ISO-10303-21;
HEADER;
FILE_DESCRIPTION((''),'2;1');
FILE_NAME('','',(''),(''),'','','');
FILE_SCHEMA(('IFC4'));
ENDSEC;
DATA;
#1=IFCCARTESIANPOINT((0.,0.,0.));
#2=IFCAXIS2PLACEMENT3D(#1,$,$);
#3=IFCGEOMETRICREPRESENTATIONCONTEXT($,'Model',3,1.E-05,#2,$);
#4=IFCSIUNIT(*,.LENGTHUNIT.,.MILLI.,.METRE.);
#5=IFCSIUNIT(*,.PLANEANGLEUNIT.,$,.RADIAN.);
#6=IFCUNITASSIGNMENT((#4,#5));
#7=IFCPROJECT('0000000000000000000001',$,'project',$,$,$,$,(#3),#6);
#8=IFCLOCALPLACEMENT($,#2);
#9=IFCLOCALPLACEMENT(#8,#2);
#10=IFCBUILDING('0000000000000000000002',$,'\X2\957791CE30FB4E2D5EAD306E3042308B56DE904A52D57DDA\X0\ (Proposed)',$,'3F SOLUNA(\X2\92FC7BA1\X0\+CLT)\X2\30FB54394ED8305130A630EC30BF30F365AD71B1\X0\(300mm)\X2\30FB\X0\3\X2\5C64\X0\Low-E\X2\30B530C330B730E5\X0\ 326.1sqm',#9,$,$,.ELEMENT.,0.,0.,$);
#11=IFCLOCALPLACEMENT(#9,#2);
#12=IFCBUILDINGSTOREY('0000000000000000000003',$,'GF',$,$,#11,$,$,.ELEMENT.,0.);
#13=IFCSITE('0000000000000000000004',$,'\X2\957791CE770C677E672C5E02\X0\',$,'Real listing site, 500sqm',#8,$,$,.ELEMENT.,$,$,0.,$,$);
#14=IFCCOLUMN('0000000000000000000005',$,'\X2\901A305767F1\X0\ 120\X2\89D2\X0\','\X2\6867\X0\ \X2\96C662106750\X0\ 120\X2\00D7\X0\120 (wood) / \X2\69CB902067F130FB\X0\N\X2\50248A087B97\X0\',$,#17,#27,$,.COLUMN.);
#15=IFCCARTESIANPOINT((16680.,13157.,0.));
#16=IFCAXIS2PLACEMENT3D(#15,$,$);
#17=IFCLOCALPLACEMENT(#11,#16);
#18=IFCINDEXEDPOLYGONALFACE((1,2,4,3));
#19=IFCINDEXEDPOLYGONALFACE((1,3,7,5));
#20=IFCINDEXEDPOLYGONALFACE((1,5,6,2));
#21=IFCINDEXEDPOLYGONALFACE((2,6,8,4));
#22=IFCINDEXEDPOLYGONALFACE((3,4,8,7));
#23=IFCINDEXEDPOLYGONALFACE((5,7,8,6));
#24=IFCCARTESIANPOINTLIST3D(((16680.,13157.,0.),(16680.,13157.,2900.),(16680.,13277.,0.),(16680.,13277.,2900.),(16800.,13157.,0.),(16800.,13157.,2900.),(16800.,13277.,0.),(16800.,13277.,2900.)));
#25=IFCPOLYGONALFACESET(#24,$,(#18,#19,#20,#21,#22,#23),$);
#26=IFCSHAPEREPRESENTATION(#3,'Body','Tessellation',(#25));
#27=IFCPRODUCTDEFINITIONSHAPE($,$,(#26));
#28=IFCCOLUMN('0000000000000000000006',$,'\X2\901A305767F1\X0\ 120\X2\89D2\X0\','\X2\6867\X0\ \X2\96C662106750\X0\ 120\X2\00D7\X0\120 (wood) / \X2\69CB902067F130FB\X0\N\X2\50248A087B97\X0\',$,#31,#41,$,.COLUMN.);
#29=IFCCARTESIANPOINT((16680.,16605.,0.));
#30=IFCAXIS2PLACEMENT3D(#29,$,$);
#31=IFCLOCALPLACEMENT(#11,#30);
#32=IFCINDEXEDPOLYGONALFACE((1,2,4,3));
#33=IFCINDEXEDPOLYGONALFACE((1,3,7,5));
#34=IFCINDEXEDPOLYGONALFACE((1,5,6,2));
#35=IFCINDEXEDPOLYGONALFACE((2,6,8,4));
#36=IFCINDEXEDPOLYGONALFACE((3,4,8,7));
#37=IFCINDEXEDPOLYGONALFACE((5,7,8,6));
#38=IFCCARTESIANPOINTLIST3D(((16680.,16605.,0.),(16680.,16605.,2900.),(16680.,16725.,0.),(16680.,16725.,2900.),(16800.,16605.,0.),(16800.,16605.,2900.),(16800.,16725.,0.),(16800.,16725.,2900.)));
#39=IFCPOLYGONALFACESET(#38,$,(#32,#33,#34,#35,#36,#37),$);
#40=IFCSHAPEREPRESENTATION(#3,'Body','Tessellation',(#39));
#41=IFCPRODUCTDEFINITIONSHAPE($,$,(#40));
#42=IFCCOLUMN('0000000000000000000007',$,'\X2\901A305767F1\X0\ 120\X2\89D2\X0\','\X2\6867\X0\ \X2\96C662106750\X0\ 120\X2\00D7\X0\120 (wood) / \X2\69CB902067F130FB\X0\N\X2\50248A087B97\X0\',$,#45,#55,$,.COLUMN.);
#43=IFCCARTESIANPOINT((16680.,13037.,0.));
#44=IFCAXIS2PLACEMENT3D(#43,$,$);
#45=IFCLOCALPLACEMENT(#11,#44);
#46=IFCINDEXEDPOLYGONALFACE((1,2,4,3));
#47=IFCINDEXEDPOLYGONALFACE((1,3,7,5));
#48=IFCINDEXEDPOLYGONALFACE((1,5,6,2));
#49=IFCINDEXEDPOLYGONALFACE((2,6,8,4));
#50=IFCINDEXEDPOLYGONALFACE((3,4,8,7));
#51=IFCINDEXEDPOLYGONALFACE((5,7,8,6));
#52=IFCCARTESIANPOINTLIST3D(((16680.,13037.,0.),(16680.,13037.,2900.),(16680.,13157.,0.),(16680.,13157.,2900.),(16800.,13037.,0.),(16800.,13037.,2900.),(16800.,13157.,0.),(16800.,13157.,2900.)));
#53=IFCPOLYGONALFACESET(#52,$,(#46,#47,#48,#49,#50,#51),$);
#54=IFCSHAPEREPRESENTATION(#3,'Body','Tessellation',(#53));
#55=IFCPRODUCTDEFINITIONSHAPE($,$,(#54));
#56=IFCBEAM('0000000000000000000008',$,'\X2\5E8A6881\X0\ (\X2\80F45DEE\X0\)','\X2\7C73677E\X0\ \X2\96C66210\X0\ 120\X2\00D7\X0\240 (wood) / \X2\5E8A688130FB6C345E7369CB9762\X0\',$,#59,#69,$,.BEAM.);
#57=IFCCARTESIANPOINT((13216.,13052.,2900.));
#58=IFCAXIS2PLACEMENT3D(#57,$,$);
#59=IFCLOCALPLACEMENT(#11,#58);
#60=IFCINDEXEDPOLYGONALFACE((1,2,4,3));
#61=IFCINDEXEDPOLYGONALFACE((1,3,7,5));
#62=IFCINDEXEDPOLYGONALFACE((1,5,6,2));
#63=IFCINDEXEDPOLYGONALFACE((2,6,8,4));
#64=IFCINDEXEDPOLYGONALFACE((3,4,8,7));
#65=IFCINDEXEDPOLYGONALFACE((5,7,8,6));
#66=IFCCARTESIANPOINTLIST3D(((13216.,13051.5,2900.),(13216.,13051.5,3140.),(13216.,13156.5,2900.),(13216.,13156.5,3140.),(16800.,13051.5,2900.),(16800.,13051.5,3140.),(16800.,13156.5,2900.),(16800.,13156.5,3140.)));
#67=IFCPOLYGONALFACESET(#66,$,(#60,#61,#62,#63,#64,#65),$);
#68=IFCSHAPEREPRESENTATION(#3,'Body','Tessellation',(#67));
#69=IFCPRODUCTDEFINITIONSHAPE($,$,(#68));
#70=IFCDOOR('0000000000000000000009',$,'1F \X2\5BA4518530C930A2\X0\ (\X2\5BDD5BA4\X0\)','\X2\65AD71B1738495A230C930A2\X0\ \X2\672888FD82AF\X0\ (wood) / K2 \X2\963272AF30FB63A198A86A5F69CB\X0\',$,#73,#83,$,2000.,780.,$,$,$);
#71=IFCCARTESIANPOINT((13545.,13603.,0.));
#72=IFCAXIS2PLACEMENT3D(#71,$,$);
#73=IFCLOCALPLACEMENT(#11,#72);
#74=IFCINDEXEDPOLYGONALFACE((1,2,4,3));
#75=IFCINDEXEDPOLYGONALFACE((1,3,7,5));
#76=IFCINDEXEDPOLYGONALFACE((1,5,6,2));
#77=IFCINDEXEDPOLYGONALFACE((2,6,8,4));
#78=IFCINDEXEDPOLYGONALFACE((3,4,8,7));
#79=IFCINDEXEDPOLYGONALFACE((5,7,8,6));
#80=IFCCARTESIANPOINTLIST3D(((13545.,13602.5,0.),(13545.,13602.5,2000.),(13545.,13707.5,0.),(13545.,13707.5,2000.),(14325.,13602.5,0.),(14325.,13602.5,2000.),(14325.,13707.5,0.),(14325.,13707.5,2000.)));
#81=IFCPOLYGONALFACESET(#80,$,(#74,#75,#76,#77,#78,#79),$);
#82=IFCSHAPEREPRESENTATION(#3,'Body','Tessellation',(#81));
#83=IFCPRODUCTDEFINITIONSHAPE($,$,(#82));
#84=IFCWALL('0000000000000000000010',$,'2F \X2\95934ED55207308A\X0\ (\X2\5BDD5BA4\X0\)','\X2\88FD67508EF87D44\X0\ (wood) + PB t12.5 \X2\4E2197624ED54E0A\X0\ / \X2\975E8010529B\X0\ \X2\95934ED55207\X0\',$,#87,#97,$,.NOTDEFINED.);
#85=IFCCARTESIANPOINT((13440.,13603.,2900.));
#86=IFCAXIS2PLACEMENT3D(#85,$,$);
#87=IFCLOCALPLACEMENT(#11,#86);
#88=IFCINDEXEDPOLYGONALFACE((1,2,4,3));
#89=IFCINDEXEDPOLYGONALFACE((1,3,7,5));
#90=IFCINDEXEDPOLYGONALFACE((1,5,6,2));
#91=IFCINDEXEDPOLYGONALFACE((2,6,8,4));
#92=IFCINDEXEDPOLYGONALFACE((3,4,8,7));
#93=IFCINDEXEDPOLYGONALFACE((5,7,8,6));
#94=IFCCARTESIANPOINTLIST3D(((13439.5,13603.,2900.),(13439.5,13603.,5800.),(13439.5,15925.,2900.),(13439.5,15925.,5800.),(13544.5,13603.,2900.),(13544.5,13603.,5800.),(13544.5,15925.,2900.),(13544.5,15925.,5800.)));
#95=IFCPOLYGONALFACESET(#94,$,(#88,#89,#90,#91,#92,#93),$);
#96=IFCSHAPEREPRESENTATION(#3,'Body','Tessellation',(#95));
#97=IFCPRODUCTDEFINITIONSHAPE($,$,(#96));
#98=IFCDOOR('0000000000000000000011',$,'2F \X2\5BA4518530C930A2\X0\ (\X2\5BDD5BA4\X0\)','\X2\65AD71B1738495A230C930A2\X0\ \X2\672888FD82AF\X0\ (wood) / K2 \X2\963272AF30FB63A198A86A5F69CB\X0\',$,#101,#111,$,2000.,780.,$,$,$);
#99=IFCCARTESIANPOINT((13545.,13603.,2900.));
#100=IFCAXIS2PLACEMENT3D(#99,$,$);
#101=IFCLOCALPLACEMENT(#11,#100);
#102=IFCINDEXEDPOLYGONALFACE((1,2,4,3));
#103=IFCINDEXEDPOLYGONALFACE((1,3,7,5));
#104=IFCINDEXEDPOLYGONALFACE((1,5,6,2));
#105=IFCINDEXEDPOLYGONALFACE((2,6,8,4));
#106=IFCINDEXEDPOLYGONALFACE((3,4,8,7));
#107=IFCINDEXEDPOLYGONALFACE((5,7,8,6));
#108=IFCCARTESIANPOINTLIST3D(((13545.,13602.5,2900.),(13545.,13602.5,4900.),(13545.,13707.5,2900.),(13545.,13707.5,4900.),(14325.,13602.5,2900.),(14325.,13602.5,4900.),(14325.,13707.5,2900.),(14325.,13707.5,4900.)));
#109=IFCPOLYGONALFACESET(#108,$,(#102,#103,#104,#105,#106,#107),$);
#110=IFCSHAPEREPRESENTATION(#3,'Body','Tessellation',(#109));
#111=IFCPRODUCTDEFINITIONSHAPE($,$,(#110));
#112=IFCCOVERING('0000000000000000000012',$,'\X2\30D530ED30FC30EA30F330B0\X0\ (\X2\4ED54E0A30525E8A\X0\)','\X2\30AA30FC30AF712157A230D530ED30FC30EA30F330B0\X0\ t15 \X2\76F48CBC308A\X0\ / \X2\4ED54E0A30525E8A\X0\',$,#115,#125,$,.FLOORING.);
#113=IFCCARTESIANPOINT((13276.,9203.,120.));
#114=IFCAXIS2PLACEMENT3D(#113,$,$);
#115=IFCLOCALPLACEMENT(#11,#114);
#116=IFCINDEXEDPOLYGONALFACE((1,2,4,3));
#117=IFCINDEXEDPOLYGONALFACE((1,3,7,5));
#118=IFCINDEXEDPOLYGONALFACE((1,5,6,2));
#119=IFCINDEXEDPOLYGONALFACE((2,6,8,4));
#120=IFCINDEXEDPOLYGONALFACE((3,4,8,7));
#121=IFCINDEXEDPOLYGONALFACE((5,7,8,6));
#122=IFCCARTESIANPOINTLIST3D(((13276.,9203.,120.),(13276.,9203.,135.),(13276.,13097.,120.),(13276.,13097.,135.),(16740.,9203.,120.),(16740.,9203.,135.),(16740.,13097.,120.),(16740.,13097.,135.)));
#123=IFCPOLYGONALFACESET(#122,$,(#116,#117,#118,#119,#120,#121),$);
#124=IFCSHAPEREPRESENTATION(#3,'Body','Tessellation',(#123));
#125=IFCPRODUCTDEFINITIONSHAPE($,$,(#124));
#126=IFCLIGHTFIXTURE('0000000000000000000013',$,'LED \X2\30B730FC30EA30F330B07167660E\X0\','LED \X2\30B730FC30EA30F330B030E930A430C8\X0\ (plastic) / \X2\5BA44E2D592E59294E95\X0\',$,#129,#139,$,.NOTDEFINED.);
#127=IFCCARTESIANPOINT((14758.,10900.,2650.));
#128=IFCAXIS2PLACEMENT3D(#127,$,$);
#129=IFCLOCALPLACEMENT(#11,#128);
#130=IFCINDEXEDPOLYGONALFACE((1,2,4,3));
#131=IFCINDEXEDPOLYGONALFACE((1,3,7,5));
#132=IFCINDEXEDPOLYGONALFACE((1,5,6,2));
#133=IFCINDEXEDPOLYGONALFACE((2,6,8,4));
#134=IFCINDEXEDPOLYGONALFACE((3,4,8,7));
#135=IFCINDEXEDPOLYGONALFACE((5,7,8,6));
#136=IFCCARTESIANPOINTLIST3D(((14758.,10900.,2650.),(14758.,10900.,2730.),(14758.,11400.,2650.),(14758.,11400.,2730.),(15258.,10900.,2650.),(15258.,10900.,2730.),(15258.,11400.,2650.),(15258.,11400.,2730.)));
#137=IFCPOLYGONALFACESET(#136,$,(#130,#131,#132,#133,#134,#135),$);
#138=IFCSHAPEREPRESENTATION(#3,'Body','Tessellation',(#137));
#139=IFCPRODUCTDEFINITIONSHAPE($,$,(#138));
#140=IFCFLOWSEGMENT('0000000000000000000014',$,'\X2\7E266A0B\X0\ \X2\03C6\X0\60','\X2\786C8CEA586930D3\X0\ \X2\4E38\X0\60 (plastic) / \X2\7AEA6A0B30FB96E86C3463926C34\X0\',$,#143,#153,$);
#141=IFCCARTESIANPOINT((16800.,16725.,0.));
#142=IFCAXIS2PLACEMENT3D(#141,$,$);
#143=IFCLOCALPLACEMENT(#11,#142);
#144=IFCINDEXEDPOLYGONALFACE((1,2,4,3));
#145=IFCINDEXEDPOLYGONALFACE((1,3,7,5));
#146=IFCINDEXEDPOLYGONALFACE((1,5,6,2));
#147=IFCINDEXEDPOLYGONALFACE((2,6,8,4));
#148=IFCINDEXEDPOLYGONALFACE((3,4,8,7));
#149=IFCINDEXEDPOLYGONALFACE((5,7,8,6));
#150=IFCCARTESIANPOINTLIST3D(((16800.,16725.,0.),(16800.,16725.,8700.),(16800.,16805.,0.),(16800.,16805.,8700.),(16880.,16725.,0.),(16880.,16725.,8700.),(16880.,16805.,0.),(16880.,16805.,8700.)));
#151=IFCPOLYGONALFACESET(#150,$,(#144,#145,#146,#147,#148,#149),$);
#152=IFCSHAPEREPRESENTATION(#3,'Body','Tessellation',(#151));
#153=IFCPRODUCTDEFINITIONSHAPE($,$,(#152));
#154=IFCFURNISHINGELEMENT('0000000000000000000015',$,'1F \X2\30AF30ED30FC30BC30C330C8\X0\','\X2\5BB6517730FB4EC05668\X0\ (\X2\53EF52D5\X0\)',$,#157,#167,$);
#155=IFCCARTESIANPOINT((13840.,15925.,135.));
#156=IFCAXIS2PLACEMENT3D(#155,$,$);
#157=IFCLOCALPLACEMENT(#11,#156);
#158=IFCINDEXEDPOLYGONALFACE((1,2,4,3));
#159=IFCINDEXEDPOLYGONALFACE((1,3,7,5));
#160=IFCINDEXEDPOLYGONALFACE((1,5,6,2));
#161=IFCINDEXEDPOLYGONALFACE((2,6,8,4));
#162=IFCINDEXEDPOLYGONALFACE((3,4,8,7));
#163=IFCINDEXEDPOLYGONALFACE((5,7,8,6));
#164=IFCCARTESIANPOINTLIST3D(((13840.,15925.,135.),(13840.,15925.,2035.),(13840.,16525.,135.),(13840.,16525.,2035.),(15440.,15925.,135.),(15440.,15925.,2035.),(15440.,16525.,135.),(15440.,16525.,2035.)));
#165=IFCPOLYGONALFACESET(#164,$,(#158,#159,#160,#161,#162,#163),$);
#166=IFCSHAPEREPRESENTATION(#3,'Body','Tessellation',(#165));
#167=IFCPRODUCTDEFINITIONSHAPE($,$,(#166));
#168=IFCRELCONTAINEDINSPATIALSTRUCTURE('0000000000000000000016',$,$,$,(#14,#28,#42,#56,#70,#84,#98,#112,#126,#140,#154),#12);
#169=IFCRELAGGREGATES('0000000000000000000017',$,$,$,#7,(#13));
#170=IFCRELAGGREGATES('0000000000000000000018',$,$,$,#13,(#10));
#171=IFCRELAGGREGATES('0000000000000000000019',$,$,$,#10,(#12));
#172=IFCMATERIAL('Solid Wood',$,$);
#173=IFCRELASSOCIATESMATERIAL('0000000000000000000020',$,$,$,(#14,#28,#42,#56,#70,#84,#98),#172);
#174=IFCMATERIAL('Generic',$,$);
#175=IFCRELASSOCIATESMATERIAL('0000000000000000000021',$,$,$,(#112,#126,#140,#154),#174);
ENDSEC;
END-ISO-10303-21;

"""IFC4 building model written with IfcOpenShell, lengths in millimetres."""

from ifc_helpers import new_model, si_unit, frame, frame_2d, origin, place, context, project, spatial, rectangle, extrude, material, element, save


model = new_model("IFC4")

# Units and contexts
model_context = context("Model", 3, precision=1e-05, world=origin())
ifc_project = project(units=[si_unit("LENGTHUNIT", "METRE", prefix="MILLI"), si_unit("PLANEANGLEUNIT", "RADIAN")], contexts=[model_context])

# Site, building, storey
site_placement = place(None, origin())
site = spatial("IfcSite", under=ifc_project, at=site_placement, Name="長野県松本市", ObjectType="Real listing site, 500sqm", CompositionType="ELEMENT", RefElevation=0.0)
building_placement = place(site_placement, origin())
building = spatial("IfcBuilding", under=site, at=building_placement, Name="長野・中庭のある回遊動線 (Proposed)", ObjectType="3F SOLUNA(鋼管+CLT)・吹付けウレタン断熱(300mm)・3層Low-Eサッシュ 326.1sqm", CompositionType="ELEMENT", ElevationOfRefHeight=0.0, ElevationOfTerrain=0.0)
storey_placement = place(building_placement, origin())
storey = spatial("IfcBuildingStorey", under=building, at=storey_placement, Name="GF", CompositionType="ELEMENT", Elevation=0.0)

# Columns
ifc_material_1 = material(Name="Solid Wood")
column_1_placement = place(storey_placement, frame((16680.0, 13157.0, 0.0)))
element("IfcColumn", 1, at=column_1_placement, inside=storey, material=ifc_material_1, Name="通し柱 120角", Description="桧 集成材 120×120 (wood) / 構造柱・N値計算", PredefinedType="COLUMN", context=model_context, shape_type="SweptSolid", body=[
    extrude(rectangle(XDim=120.0, YDim=120.0, at=frame_2d((60.0, 60.0))), frame((16680.0, 13157.0, 0.0)), (0.0, 0.0, 1.0), 2900.0),
])
column_2_placement = place(storey_placement, frame((16680.0, 16605.0, 0.0)))
element("IfcColumn", 2, at=column_2_placement, inside=storey, material=ifc_material_1, Name="通し柱 120角", Description="桧 集成材 120×120 (wood) / 構造柱・N値計算", PredefinedType="COLUMN", context=model_context, shape_type="SweptSolid", body=[
    extrude(rectangle(XDim=120.0, YDim=120.0, at=frame_2d((60.0, 60.0))), frame((16680.0, 16605.0, 0.0)), (0.0, 0.0, 1.0), 2900.0),
])
column_3_placement = place(storey_placement, frame((16680.0, 13037.0, 0.0)))
element("IfcColumn", 3, at=column_3_placement, inside=storey, material=ifc_material_1, Name="通し柱 120角", Description="桧 集成材 120×120 (wood) / 構造柱・N値計算", PredefinedType="COLUMN", context=model_context, shape_type="SweptSolid", body=[
    extrude(rectangle(XDim=120.0, YDim=120.0, at=frame_2d((60.0, 60.0))), frame((16680.0, 13037.0, 0.0)), (0.0, 0.0, 1.0), 2900.0),
])

# Beam
beam_1_placement = place(storey_placement, frame((13216.0, 13052.0, 2900.0)))
element("IfcBeam", 4, at=beam_1_placement, inside=storey, material=ifc_material_1, Name="床梁 (胴差)", Description="米松 集成 120×240 (wood) / 床梁・水平構面", PredefinedType="BEAM", context=model_context, shape_type="SweptSolid", body=[
    extrude(rectangle(XDim=3584.0, YDim=105.0, at=frame_2d((1792.0, 52.0))), frame((13216.0, 13052.0, 2900.0)), (0.0, 0.0, 1.0), 240.0),
])

# Door
door_1_placement = place(storey_placement, frame((13545.0, 13603.0, 0.0)))
element("IfcDoor", 5, at=door_1_placement, inside=storey, material=ifc_material_1, Name="1F 室内ドア (寝室)", Description="断熱玄関ドア 木製芯 (wood) / K2 防犯・採風機構", OverallHeight=2000.0, OverallWidth=780.0, context=model_context, shape_type="SweptSolid", body=[
    extrude(rectangle(XDim=780.0, YDim=105.0, at=frame_2d((390.0, 52.0))), frame((13545.0, 13603.0, 0.0)), (0.0, 0.0, 1.0), 2000.0),
])

# Wall
wall_1_placement = place(storey_placement, frame((13440.0, 13603.0, 2900.0)))
element("IfcWall", 6, at=wall_1_placement, inside=storey, material=ifc_material_1, Name="2F 間仕切り (寝室)", Description="製材軸組 (wood) + PB t12.5 両面仕上 / 非耐力 間仕切", PredefinedType="NOTDEFINED", context=model_context, shape_type="SweptSolid", body=[
    extrude(rectangle(XDim=105.0, YDim=2322.0, at=frame_2d((52.0, 1161.0))), frame((13440.0, 13603.0, 2900.0)), (0.0, 0.0, 1.0), 2900.0),
])

# Door
door_2_placement = place(storey_placement, frame((13545.0, 13603.0, 2900.0)))
element("IfcDoor", 7, at=door_2_placement, inside=storey, material=ifc_material_1, Name="2F 室内ドア (寝室)", Description="断熱玄関ドア 木製芯 (wood) / K2 防犯・採風機構", OverallHeight=2000.0, OverallWidth=780.0, context=model_context, shape_type="SweptSolid", body=[
    extrude(rectangle(XDim=780.0, YDim=105.0, at=frame_2d((390.0, 52.0))), frame((13545.0, 13603.0, 2900.0)), (0.0, 0.0, 1.0), 2000.0),
])

# Covering
ifc_material_2 = material(Name="Generic")
covering_placement = place(storey_placement, frame((13276.0, 9203.0, 120.0)))
element("IfcCovering", 8, at=covering_placement, inside=storey, material=ifc_material_2, Name="フローリング (仕上げ床)", Description="オーク無垢フローリング t15 直貼り / 仕上げ床", PredefinedType="FLOORING", context=model_context, shape_type="SweptSolid", body=[
    extrude(rectangle(XDim=3464.0, YDim=3894.0, at=frame_2d((1732.0, 1947.0))), frame((13276.0, 9203.0, 120.0)), (0.0, 0.0, 1.0), 15.0),
])

# Light fixture
light_fixture_placement = place(storey_placement, frame((14758.0, 10900.0, 2650.0)))
element("IfcLightFixture", 9, at=light_fixture_placement, inside=storey, material=ifc_material_2, Name="LED シーリング照明", Description="LED シーリングライト (plastic) / 室中央天井", PredefinedType="NOTDEFINED", context=model_context, shape_type="SweptSolid", body=[
    extrude(rectangle(XDim=500.0, YDim=500.0, at=frame_2d((250.0, 250.0))), frame((14758.0, 10900.0, 2650.0)), (0.0, 0.0, 1.0), 80.0),
])

# Flow segment
flow_segment_placement = place(storey_placement, frame((16800.0, 16725.0, 0.0)))
element("IfcFlowSegment", 10, at=flow_segment_placement, inside=storey, material=ifc_material_2, Name="縦樋 φ60", Description="硬質塩ビ 丸60 (plastic) / 竪樋・雨水排水", context=model_context, shape_type="SweptSolid", body=[
    extrude(rectangle(XDim=80.0, YDim=80.0, at=frame_2d((40.0, 40.0))), frame((16800.0, 16725.0, 0.0)), (0.0, 0.0, 1.0), 8700.0),
])

# Furnishing element
furnishing_placement = place(storey_placement, frame((13840.0, 15925.0, 135.0)))
element("IfcFurnishingElement", 11, at=furnishing_placement, inside=storey, material=ifc_material_2, Name="1F クローゼット", Description="家具・什器 (可動)", context=model_context, shape_type="SweptSolid", body=[
    extrude(rectangle(XDim=1600.0, YDim=600.0, at=frame_2d((800.0, 300.0))), frame((13840.0, 15925.0, 135.0)), (0.0, 0.0, 1.0), 1900.0),
])

save(model, "model.ifc")
